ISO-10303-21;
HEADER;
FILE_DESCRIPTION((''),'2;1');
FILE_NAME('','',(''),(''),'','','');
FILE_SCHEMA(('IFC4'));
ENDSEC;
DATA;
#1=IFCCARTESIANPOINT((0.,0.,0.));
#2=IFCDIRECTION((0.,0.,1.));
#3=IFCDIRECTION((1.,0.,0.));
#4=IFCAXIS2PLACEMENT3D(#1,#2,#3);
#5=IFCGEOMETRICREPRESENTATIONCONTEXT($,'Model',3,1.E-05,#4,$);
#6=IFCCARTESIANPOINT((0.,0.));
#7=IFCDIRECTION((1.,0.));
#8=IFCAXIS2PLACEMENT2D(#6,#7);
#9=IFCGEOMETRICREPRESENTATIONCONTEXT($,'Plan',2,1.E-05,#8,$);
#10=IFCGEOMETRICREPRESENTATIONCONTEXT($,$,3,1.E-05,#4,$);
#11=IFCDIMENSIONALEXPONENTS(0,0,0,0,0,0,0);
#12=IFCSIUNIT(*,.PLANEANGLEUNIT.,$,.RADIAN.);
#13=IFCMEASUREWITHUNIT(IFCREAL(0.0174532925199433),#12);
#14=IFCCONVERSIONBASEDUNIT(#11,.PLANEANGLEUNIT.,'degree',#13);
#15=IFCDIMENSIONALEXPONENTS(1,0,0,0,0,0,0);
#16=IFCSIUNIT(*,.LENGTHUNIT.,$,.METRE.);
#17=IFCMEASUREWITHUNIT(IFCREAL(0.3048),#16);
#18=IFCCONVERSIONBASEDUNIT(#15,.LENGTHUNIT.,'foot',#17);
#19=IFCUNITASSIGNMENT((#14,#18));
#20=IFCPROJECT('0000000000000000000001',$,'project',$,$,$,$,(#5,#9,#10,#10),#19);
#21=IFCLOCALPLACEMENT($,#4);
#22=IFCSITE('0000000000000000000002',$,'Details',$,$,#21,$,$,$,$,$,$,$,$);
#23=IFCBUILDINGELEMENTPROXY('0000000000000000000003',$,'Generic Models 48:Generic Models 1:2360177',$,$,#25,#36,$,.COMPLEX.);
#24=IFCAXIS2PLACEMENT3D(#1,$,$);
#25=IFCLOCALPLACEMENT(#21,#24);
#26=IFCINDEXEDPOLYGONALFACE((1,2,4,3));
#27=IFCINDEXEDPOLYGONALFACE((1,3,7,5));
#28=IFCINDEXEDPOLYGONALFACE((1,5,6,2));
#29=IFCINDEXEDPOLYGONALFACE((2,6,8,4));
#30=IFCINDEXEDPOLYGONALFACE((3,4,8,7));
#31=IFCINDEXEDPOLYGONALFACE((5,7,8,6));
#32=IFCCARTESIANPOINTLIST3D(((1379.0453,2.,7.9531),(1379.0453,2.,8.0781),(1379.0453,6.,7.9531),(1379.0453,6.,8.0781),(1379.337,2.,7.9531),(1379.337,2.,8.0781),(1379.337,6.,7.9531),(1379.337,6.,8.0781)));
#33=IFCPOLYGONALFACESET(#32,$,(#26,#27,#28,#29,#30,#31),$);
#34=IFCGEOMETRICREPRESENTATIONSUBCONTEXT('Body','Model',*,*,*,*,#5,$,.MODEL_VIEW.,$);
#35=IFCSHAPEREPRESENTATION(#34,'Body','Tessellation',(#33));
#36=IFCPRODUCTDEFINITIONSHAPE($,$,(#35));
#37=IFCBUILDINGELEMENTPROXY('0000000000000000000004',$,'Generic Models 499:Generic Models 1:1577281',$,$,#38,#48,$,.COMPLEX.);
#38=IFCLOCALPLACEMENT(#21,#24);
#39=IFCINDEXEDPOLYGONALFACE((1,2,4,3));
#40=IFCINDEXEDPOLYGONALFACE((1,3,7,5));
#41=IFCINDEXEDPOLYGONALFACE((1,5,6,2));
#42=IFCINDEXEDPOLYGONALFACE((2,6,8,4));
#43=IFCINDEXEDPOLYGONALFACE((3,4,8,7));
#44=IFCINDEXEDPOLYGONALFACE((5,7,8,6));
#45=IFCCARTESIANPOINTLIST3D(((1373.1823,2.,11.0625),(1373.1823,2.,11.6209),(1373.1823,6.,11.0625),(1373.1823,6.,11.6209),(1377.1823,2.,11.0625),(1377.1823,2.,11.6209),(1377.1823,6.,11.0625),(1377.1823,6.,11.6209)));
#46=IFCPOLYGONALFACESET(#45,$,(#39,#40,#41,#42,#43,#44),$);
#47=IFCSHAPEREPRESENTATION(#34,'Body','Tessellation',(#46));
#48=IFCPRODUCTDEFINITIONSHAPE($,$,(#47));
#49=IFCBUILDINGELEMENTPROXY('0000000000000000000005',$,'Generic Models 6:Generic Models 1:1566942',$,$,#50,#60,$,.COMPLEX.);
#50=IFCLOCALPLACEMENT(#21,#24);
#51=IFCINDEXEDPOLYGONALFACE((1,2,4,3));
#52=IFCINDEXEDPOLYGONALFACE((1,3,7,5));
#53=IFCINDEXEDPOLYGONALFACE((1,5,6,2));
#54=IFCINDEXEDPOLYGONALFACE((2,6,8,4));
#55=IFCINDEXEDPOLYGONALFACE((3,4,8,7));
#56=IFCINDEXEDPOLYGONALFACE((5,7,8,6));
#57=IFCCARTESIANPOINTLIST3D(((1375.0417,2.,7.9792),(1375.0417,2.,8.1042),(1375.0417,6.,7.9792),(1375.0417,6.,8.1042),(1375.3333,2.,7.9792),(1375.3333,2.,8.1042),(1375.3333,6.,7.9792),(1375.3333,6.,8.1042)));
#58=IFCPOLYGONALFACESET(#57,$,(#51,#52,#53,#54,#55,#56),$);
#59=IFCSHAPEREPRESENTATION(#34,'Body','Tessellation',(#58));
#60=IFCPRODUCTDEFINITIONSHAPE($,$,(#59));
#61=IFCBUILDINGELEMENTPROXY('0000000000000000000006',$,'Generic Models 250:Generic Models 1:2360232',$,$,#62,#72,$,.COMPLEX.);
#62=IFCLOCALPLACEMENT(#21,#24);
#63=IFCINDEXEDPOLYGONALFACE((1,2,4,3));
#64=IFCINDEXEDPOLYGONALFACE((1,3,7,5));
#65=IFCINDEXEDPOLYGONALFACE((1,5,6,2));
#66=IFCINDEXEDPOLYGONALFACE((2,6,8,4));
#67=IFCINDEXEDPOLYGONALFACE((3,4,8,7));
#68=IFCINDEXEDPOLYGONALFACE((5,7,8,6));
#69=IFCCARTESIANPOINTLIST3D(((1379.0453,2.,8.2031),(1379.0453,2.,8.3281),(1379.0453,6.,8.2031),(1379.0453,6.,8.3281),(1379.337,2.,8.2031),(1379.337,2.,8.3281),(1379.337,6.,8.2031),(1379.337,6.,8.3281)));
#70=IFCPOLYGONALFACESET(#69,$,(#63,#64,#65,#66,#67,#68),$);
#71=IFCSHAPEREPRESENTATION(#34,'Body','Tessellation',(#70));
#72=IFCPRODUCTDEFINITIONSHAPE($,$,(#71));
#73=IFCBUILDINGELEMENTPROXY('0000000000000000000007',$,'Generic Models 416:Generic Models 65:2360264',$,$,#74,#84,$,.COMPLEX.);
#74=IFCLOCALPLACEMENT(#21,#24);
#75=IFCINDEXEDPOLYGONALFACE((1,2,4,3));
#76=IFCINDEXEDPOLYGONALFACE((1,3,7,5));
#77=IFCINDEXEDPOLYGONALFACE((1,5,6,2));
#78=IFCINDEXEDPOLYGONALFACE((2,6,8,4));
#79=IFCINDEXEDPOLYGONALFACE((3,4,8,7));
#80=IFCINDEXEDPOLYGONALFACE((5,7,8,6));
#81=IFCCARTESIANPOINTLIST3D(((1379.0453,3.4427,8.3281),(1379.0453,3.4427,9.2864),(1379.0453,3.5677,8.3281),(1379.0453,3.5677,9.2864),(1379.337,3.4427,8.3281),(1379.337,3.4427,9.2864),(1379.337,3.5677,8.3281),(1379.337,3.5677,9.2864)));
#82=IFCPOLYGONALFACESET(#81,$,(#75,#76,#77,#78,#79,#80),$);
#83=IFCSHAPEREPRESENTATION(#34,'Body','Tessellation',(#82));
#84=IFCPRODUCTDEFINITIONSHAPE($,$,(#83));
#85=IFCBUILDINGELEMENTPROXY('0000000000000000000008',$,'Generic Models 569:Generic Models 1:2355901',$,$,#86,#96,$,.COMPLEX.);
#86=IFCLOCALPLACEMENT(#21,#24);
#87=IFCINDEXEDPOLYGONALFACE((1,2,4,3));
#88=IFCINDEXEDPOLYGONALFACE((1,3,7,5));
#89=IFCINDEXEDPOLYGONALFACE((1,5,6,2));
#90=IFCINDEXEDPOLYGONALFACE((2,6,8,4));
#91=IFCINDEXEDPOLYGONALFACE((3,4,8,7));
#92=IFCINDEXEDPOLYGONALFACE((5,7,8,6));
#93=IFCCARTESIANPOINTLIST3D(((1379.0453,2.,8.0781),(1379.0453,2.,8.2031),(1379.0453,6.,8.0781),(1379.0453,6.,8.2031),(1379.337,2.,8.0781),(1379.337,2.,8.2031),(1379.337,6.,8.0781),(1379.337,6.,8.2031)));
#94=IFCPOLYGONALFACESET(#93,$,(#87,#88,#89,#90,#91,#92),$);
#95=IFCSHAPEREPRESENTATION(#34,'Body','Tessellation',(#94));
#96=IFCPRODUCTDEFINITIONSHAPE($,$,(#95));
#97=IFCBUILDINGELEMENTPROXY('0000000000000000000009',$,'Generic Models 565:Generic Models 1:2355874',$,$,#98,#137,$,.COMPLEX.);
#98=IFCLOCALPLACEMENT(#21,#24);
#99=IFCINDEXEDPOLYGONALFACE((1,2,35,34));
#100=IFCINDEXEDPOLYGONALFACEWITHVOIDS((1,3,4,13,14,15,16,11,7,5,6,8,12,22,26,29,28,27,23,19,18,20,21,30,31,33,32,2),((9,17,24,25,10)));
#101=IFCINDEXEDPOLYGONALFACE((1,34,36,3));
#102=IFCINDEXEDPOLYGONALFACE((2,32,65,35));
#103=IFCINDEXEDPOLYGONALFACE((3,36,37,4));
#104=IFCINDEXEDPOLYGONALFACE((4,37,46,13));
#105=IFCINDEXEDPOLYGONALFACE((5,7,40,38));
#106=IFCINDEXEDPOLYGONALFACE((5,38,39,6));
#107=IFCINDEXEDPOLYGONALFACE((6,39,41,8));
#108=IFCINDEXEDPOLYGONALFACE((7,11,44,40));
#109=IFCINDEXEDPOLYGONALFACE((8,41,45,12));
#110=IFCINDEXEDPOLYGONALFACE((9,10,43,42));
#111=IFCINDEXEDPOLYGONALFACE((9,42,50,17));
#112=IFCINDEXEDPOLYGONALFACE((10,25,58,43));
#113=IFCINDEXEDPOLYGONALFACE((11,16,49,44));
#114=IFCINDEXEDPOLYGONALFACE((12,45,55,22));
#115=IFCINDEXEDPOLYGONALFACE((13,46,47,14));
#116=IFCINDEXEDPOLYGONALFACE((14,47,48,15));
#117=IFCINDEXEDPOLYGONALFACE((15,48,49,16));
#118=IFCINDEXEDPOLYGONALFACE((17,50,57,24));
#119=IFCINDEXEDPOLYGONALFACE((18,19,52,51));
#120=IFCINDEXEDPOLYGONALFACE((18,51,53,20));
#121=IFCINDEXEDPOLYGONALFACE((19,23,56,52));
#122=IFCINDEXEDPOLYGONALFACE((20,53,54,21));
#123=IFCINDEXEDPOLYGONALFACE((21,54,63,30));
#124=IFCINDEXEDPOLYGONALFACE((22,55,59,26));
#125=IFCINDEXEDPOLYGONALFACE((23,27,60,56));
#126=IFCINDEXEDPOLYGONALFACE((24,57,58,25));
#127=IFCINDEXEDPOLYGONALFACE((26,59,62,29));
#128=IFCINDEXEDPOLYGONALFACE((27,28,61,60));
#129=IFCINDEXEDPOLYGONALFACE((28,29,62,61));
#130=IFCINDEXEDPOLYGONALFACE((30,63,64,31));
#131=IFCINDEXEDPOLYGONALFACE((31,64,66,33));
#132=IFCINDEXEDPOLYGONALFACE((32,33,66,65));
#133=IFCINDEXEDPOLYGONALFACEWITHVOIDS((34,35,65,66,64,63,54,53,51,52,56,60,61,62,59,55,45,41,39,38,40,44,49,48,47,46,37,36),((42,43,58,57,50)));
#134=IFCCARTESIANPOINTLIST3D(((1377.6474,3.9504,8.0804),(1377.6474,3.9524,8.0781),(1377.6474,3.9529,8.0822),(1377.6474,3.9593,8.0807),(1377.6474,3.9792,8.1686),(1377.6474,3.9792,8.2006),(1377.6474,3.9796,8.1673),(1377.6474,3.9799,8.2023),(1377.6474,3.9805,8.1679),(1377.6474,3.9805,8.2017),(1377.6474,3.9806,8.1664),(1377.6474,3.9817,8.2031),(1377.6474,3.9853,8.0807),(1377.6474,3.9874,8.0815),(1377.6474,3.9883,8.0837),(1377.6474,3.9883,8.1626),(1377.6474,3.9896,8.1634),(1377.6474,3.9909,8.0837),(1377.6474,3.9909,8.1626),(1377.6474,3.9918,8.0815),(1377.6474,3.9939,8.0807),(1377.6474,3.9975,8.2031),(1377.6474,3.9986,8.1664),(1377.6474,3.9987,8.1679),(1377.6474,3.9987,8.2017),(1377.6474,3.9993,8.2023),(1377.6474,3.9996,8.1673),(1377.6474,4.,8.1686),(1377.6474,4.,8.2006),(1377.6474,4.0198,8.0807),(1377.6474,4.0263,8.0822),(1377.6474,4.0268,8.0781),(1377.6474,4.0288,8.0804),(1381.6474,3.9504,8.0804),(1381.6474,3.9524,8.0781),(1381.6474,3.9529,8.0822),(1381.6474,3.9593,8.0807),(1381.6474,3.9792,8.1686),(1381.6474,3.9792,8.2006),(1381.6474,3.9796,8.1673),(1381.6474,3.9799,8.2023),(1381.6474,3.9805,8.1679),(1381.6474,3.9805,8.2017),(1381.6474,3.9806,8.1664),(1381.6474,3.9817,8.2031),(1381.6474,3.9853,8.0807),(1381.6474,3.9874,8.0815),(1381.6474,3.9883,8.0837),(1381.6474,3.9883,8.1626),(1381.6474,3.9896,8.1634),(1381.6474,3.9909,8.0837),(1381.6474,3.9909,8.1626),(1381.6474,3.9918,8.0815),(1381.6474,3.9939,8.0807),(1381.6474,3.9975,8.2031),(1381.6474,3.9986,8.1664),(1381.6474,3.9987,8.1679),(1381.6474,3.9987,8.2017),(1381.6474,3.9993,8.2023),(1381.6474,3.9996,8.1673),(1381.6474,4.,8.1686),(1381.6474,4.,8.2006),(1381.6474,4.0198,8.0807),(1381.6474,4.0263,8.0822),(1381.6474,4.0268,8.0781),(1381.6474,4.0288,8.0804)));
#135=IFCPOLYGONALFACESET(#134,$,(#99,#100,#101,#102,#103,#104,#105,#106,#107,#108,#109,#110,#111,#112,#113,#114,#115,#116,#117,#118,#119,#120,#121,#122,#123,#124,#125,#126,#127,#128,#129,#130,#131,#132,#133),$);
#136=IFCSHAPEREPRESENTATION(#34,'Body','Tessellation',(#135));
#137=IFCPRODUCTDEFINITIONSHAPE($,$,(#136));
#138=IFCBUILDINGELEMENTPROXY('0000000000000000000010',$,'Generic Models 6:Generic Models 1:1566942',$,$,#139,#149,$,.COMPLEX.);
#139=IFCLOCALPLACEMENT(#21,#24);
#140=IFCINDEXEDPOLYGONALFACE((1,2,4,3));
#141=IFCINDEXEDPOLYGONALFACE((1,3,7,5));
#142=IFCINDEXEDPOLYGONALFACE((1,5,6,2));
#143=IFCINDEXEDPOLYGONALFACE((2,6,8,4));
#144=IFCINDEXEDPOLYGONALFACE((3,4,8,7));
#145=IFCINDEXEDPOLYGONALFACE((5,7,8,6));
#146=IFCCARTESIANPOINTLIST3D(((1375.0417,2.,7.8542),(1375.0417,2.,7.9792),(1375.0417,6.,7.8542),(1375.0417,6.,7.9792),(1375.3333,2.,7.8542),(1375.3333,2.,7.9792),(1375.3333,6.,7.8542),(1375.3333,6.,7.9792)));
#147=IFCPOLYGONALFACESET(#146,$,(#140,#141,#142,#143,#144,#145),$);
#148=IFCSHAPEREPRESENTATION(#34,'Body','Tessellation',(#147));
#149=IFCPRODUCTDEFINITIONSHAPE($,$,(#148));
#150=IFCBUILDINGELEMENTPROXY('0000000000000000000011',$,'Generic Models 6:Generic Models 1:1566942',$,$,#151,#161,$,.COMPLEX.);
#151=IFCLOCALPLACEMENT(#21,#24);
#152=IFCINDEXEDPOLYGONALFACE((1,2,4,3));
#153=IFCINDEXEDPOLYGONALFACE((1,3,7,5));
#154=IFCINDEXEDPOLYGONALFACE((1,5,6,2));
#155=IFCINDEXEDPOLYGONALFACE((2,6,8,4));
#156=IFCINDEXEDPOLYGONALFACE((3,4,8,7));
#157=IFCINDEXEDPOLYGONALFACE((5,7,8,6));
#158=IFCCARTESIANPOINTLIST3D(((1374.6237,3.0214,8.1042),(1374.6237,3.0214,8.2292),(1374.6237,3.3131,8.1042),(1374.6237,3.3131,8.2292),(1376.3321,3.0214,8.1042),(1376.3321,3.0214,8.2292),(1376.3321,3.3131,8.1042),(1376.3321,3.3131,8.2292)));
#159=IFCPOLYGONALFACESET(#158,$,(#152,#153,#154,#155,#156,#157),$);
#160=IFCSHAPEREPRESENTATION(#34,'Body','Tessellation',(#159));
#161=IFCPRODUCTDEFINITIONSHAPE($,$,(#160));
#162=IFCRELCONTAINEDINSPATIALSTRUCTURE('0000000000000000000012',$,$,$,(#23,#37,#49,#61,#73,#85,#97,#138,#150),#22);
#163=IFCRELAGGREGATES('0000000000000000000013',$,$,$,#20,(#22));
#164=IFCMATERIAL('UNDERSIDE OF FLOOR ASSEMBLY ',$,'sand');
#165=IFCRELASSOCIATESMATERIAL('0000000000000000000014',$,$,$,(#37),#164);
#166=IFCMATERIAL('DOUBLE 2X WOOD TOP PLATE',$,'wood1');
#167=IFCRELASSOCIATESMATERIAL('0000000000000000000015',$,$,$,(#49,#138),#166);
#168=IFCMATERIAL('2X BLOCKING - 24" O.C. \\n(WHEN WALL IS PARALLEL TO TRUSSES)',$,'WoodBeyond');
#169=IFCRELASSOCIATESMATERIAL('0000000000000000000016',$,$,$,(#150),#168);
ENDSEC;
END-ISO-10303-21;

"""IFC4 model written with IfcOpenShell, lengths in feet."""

from ifc_helpers import new_model, entity, si_unit, converted_unit, frame, origin_with_axes, origin_2d_with_axis, place, context, subcontext, project, spatial, polyline, line, indexed_curve, outline, extrude, material, element, save


model = new_model("IFC4")

# Units and contexts
model_context = context("Model", 3, precision=1e-05, world=origin_with_axes())
plan_context = context("Plan", 2, precision=1e-05, world=origin_2d_with_axis())
context_of_model = context(None, 3, precision=1e-05, world=origin_with_axes())
body_context = subcontext(model_context, "Body", "Model", "MODEL_VIEW")
ifc_project = project(units=[converted_unit("PLANEANGLEUNIT", "degree", entity("IfcReal", 0.0174532925199433), si_unit("PLANEANGLEUNIT", "RADIAN"), dimensions=[0, 0, 0, 0, 0, 0, 0]), converted_unit("LENGTHUNIT", "foot", entity("IfcReal", 0.3048), si_unit("LENGTHUNIT", "METRE"), dimensions=[1, 0, 0, 0, 0, 0, 0])], contexts=[model_context, plan_context, context_of_model, context_of_model])

# Site
site_placement = place(None, origin_with_axes())
site = spatial("IfcSite", under=ifc_project, at=site_placement, Name="Details")

# Building element proxies
proxy_1_placement = place(site_placement, frame((1379.0453, 6.0, 7.9531), z_axis=(0.0, -1.0, 0.0), x_axis=(0.0, 0.0, 1.0)))
element("IfcBuildingElementProxy", 1, at=proxy_1_placement, inside=site, Name="Generic Models 48:Generic Models 1:2360177", PredefinedType="COMPLEX", context=body_context, shape_type="SweptSolid", body=[
    extrude(outline(polyline([(-0.1458, -0.0625), (0.1458, -0.0625), (0.1458, 0.0625), (-0.1458, 0.0625), (-0.1458, -0.0625)])), frame((0.0625, -0.1458, 0.0), z_axis=(0.0, 0.0, -1.0), x_axis=(0.0, 1.0, 0.0)), (0.0, 0.0, -1.0), 4.0),
])
ifc_material_1 = material(Name="UNDERSIDE OF FLOOR ASSEMBLY ", Category="sand")
proxy_2_placement = place(site_placement, frame((1373.1823, 6.0, 11.0625), z_axis=(0.0, -1.0, 0.0), x_axis=(0.0, 0.0, -1.0)))
element("IfcBuildingElementProxy", 2, at=proxy_2_placement, inside=site, material=ifc_material_1, Name="Generic Models 499:Generic Models 1:1577281", PredefinedType="COMPLEX", context=body_context, shape_type="SweptSolid", body=[
    extrude(outline(indexed_curve([(-0.2792, -2.0), (0.2792, -2.0), (0.2792, 2.0), (-0.2792, 2.0)], segments=[line(3, 2), line(2, 1), line(1, 4), line(4, 3)], self_intersect=False)), frame((-0.2792, 2.0, 0.0), z_axis=(0.0, 0.0, -1.0), x_axis=(1.0, 0.0, 0.0)), (0.0, 0.0, -1.0), 4.0),
])
ifc_material_2 = material(Name="DOUBLE 2X WOOD TOP PLATE", Category="wood1")
proxy_3_placement = place(site_placement, frame((1375.0417, 6.0, 7.9792), z_axis=(0.0, -1.0, 0.0), x_axis=(0.0, 0.0, -1.0)))
element("IfcBuildingElementProxy", 3, at=proxy_3_placement, inside=site, material=ifc_material_2, Name="Generic Models 6:Generic Models 1:1566942", PredefinedType="COMPLEX", context=body_context, shape_type="SweptSolid", body=[
    extrude(outline(indexed_curve([(-0.0625, -0.1458), (0.0625, -0.1458), (0.0625, 0.1458), (-0.0625, 0.1458)], segments=[line(3, 2), line(2, 1), line(1, 4), line(4, 3)], self_intersect=False)), frame((-0.0625, 0.1458, 0.0), z_axis=(0.0, 0.0, -1.0), x_axis=(-1.0, 0.0, 0.0)), (0.0, 0.0, -1.0), 4.0),
])
proxy_4_placement = place(site_placement, frame((1379.0453, 6.0, 8.2031), z_axis=(0.0, -1.0, 0.0), x_axis=(0.0, 0.0, 1.0)))
element("IfcBuildingElementProxy", 4, at=proxy_4_placement, inside=site, Name="Generic Models 250:Generic Models 1:2360232", PredefinedType="COMPLEX", context=body_context, shape_type="SweptSolid", body=[
    extrude(outline(polyline([(-0.0625, -0.1458), (0.0625, -0.1458), (0.0625, 0.1458), (-0.0625, 0.1458), (-0.0625, -0.1458)])), frame((0.0625, -0.1458, 0.0), z_axis=(0.0, 0.0, -1.0), x_axis=(-1.0, 0.0, 0.0)), (0.0, 0.0, -1.0), 4.0),
])
proxy_5_placement = place(site_placement, frame((1379.0453, 3.4427, 8.3281), z_axis=(0.0, 0.0, 1.0), x_axis=(1.0, 0.0, 0.0)))
element("IfcBuildingElementProxy", 5, at=proxy_5_placement, inside=site, Name="Generic Models 416:Generic Models 65:2360264", PredefinedType="COMPLEX", context=body_context, shape_type="SweptSolid", body=[
    extrude(outline(polyline([(-0.1458, -0.0625), (0.1458, -0.0625), (0.1458, 0.0625), (-0.1458, 0.0625), (-0.1458, -0.0625)])), frame((0.1458, 0.0625, 0.0), z_axis=(0.0, 0.0, -1.0), x_axis=(-1.0, 0.0, 0.0)), (0.0, 0.0, -1.0), 0.9583),
])
proxy_6_placement = place(site_placement, frame((1379.0453, 6.0, 8.0781), z_axis=(0.0, -1.0, 0.0), x_axis=(0.0, 0.0, 1.0)))
element("IfcBuildingElementProxy", 6, at=proxy_6_placement, inside=site, Name="Generic Models 569:Generic Models 1:2355901", PredefinedType="COMPLEX", context=body_context, shape_type="SweptSolid", body=[
    extrude(outline(polyline([(-0.1458, -0.0625), (0.1458, -0.0625), (0.1458, 0.0625), (-0.1458, 0.0625), (-0.1458, -0.0625)])), frame((0.0625, -0.1458, 0.0), z_axis=(0.0, 0.0, -1.0), x_axis=(0.0, 1.0, 0.0)), (0.0, 0.0, -1.0), 4.0),
])
proxy_7_placement = place(site_placement, frame((1377.6474, 3.9503, 8.0781), z_axis=(1.0, 0.0, 0.0), x_axis=(0.0, 0.0, 1.0)))
element("IfcBuildingElementProxy", 7, at=proxy_7_placement, inside=site, Name="Generic Models 565:Generic Models 1:2355874", PredefinedType="COMPLEX", context=body_context, shape_type="SweptSolid", body=[
    extrude(outline(indexed_curve([(0.0297, 0.0058), (0.0311, 0.006), (0.0627, 0.0015), (0.0643, 0.0005), (0.0648, -0.0014), (0.0625, -0.017), (0.0615, -0.0187), (0.0597, -0.0192), (0.0281, -0.0146), (0.0268, -0.014), (0.0261, -0.0129), (0.0234, -0.0047), (-0.0547, 0.0066), (-0.0569, 0.006), (-0.0581, 0.0041), (-0.0618, -0.0216), (-0.0612, -0.0282), (-0.0634, -0.0305), (-0.0654, -0.0281), (-0.0547, 0.0455), (-0.0522, 0.0472), (-0.0507, 0.0444), (-0.0532, 0.0382), (-0.0569, 0.0126), (-0.0563, 0.0103), (-0.0543, 0.0092), (0.0238, -0.0021), (0.0286, 0.005), (0.0301, 0.0048), (0.0637, 0.0), (0.0611, -0.018), (0.0275, -0.0132), (0.0244, -0.0035)], segments=[line(7, 6), line(6, 5), line(5, 4), line(4, 3), line(3, 2), line(2, 1), line(1, 28), line(28, 27), line(27, 26), line(26, 25), line(25, 24), line(24, 23), line(23, 22), line(22, 21), line(21, 20), line(20, 19), line(19, 18), line(18, 17), line(17, 16), line(16, 15), line(15, 14), line(14, 13), line(13, 12), line(12, 11), line(11, 10), line(10, 9), line(9, 8), line(8, 7)], self_intersect=False), holes=[indexed_curve([(0.0297, 0.0058), (0.0311, 0.006), (0.0627, 0.0015), (0.0643, 0.0005), (0.0648, -0.0014), (0.0625, -0.017), (0.0615, -0.0187), (0.0597, -0.0192), (0.0281, -0.0146), (0.0268, -0.014), (0.0261, -0.0129), (0.0234, -0.0047), (-0.0547, 0.0066), (-0.0569, 0.006), (-0.0581, 0.0041), (-0.0618, -0.0216), (-0.0612, -0.0282), (-0.0634, -0.0305), (-0.0654, -0.0281), (-0.0547, 0.0455), (-0.0522, 0.0472), (-0.0507, 0.0444), (-0.0532, 0.0382), (-0.0569, 0.0126), (-0.0563, 0.0103), (-0.0543, 0.0092), (0.0238, -0.0021), (0.0286, 0.005), (0.0301, 0.0048), (0.0637, 0.0), (0.0611, -0.018), (0.0275, -0.0132), (0.0244, -0.0035)], segments=[line(31, 32), line(32, 33), line(33, 29), line(29, 30), line(30, 31)], self_intersect=False)]), frame((0.0607, -0.0392, 0.0), z_axis=(0.0, 0.0, -1.0), x_axis=(0.989698, -0.14317, 0.0)), (0.0, 0.0, -1.0), 4.0),
])
proxy_8_placement = place(site_placement, frame((1375.0417, 6.0, 7.8542), z_axis=(0.0, -1.0, 0.0), x_axis=(0.0, 0.0, -1.0)))
element("IfcBuildingElementProxy", 8, at=proxy_8_placement, inside=site, material=ifc_material_2, Name="Generic Models 6:Generic Models 1:1566942", PredefinedType="COMPLEX", context=body_context, shape_type="SweptSolid", body=[
    extrude(outline(indexed_curve([(-0.0625, -0.1458), (0.0625, -0.1458), (0.0625, 0.1458), (-0.0625, 0.1458)], segments=[line(3, 2), line(2, 1), line(1, 4), line(4, 3)], self_intersect=False)), frame((-0.0625, 0.1458, 0.0), z_axis=(0.0, 0.0, -1.0), x_axis=(-1.0, 0.0, 0.0)), (0.0, 0.0, -1.0), 4.0),
])
ifc_material_3 = material(Name="2X BLOCKING - 24\" O.C. \\n(WHEN WALL IS PARALLEL TO TRUSSES)", Category="WoodBeyond")
proxy_9_placement = place(site_placement, frame((1376.3321, 3.3131, 8.1042), z_axis=(-1.0, 0.0, 0.0), x_axis=(0.0, 0.0, -1.0)))
element("IfcBuildingElementProxy", 9, at=proxy_9_placement, inside=site, material=ifc_material_3, Name="Generic Models 6:Generic Models 1:1566942", PredefinedType="COMPLEX", context=body_context, shape_type="SweptSolid", body=[
    extrude(outline(indexed_curve([(-0.0625, -0.1458), (0.0625, -0.1458), (0.0625, 0.1458), (-0.0625, 0.1458)], segments=[line(4, 1), line(1, 2), line(2, 3), line(3, 4)], self_intersect=False)), frame((-0.0625, 0.1458, 0.0), z_axis=(0.0, 0.0, -1.0), x_axis=(1.0, 0.0, 0.0)), (0.0, 0.0, -1.0), 1.7083),
])

save(model, "model.ifc")
